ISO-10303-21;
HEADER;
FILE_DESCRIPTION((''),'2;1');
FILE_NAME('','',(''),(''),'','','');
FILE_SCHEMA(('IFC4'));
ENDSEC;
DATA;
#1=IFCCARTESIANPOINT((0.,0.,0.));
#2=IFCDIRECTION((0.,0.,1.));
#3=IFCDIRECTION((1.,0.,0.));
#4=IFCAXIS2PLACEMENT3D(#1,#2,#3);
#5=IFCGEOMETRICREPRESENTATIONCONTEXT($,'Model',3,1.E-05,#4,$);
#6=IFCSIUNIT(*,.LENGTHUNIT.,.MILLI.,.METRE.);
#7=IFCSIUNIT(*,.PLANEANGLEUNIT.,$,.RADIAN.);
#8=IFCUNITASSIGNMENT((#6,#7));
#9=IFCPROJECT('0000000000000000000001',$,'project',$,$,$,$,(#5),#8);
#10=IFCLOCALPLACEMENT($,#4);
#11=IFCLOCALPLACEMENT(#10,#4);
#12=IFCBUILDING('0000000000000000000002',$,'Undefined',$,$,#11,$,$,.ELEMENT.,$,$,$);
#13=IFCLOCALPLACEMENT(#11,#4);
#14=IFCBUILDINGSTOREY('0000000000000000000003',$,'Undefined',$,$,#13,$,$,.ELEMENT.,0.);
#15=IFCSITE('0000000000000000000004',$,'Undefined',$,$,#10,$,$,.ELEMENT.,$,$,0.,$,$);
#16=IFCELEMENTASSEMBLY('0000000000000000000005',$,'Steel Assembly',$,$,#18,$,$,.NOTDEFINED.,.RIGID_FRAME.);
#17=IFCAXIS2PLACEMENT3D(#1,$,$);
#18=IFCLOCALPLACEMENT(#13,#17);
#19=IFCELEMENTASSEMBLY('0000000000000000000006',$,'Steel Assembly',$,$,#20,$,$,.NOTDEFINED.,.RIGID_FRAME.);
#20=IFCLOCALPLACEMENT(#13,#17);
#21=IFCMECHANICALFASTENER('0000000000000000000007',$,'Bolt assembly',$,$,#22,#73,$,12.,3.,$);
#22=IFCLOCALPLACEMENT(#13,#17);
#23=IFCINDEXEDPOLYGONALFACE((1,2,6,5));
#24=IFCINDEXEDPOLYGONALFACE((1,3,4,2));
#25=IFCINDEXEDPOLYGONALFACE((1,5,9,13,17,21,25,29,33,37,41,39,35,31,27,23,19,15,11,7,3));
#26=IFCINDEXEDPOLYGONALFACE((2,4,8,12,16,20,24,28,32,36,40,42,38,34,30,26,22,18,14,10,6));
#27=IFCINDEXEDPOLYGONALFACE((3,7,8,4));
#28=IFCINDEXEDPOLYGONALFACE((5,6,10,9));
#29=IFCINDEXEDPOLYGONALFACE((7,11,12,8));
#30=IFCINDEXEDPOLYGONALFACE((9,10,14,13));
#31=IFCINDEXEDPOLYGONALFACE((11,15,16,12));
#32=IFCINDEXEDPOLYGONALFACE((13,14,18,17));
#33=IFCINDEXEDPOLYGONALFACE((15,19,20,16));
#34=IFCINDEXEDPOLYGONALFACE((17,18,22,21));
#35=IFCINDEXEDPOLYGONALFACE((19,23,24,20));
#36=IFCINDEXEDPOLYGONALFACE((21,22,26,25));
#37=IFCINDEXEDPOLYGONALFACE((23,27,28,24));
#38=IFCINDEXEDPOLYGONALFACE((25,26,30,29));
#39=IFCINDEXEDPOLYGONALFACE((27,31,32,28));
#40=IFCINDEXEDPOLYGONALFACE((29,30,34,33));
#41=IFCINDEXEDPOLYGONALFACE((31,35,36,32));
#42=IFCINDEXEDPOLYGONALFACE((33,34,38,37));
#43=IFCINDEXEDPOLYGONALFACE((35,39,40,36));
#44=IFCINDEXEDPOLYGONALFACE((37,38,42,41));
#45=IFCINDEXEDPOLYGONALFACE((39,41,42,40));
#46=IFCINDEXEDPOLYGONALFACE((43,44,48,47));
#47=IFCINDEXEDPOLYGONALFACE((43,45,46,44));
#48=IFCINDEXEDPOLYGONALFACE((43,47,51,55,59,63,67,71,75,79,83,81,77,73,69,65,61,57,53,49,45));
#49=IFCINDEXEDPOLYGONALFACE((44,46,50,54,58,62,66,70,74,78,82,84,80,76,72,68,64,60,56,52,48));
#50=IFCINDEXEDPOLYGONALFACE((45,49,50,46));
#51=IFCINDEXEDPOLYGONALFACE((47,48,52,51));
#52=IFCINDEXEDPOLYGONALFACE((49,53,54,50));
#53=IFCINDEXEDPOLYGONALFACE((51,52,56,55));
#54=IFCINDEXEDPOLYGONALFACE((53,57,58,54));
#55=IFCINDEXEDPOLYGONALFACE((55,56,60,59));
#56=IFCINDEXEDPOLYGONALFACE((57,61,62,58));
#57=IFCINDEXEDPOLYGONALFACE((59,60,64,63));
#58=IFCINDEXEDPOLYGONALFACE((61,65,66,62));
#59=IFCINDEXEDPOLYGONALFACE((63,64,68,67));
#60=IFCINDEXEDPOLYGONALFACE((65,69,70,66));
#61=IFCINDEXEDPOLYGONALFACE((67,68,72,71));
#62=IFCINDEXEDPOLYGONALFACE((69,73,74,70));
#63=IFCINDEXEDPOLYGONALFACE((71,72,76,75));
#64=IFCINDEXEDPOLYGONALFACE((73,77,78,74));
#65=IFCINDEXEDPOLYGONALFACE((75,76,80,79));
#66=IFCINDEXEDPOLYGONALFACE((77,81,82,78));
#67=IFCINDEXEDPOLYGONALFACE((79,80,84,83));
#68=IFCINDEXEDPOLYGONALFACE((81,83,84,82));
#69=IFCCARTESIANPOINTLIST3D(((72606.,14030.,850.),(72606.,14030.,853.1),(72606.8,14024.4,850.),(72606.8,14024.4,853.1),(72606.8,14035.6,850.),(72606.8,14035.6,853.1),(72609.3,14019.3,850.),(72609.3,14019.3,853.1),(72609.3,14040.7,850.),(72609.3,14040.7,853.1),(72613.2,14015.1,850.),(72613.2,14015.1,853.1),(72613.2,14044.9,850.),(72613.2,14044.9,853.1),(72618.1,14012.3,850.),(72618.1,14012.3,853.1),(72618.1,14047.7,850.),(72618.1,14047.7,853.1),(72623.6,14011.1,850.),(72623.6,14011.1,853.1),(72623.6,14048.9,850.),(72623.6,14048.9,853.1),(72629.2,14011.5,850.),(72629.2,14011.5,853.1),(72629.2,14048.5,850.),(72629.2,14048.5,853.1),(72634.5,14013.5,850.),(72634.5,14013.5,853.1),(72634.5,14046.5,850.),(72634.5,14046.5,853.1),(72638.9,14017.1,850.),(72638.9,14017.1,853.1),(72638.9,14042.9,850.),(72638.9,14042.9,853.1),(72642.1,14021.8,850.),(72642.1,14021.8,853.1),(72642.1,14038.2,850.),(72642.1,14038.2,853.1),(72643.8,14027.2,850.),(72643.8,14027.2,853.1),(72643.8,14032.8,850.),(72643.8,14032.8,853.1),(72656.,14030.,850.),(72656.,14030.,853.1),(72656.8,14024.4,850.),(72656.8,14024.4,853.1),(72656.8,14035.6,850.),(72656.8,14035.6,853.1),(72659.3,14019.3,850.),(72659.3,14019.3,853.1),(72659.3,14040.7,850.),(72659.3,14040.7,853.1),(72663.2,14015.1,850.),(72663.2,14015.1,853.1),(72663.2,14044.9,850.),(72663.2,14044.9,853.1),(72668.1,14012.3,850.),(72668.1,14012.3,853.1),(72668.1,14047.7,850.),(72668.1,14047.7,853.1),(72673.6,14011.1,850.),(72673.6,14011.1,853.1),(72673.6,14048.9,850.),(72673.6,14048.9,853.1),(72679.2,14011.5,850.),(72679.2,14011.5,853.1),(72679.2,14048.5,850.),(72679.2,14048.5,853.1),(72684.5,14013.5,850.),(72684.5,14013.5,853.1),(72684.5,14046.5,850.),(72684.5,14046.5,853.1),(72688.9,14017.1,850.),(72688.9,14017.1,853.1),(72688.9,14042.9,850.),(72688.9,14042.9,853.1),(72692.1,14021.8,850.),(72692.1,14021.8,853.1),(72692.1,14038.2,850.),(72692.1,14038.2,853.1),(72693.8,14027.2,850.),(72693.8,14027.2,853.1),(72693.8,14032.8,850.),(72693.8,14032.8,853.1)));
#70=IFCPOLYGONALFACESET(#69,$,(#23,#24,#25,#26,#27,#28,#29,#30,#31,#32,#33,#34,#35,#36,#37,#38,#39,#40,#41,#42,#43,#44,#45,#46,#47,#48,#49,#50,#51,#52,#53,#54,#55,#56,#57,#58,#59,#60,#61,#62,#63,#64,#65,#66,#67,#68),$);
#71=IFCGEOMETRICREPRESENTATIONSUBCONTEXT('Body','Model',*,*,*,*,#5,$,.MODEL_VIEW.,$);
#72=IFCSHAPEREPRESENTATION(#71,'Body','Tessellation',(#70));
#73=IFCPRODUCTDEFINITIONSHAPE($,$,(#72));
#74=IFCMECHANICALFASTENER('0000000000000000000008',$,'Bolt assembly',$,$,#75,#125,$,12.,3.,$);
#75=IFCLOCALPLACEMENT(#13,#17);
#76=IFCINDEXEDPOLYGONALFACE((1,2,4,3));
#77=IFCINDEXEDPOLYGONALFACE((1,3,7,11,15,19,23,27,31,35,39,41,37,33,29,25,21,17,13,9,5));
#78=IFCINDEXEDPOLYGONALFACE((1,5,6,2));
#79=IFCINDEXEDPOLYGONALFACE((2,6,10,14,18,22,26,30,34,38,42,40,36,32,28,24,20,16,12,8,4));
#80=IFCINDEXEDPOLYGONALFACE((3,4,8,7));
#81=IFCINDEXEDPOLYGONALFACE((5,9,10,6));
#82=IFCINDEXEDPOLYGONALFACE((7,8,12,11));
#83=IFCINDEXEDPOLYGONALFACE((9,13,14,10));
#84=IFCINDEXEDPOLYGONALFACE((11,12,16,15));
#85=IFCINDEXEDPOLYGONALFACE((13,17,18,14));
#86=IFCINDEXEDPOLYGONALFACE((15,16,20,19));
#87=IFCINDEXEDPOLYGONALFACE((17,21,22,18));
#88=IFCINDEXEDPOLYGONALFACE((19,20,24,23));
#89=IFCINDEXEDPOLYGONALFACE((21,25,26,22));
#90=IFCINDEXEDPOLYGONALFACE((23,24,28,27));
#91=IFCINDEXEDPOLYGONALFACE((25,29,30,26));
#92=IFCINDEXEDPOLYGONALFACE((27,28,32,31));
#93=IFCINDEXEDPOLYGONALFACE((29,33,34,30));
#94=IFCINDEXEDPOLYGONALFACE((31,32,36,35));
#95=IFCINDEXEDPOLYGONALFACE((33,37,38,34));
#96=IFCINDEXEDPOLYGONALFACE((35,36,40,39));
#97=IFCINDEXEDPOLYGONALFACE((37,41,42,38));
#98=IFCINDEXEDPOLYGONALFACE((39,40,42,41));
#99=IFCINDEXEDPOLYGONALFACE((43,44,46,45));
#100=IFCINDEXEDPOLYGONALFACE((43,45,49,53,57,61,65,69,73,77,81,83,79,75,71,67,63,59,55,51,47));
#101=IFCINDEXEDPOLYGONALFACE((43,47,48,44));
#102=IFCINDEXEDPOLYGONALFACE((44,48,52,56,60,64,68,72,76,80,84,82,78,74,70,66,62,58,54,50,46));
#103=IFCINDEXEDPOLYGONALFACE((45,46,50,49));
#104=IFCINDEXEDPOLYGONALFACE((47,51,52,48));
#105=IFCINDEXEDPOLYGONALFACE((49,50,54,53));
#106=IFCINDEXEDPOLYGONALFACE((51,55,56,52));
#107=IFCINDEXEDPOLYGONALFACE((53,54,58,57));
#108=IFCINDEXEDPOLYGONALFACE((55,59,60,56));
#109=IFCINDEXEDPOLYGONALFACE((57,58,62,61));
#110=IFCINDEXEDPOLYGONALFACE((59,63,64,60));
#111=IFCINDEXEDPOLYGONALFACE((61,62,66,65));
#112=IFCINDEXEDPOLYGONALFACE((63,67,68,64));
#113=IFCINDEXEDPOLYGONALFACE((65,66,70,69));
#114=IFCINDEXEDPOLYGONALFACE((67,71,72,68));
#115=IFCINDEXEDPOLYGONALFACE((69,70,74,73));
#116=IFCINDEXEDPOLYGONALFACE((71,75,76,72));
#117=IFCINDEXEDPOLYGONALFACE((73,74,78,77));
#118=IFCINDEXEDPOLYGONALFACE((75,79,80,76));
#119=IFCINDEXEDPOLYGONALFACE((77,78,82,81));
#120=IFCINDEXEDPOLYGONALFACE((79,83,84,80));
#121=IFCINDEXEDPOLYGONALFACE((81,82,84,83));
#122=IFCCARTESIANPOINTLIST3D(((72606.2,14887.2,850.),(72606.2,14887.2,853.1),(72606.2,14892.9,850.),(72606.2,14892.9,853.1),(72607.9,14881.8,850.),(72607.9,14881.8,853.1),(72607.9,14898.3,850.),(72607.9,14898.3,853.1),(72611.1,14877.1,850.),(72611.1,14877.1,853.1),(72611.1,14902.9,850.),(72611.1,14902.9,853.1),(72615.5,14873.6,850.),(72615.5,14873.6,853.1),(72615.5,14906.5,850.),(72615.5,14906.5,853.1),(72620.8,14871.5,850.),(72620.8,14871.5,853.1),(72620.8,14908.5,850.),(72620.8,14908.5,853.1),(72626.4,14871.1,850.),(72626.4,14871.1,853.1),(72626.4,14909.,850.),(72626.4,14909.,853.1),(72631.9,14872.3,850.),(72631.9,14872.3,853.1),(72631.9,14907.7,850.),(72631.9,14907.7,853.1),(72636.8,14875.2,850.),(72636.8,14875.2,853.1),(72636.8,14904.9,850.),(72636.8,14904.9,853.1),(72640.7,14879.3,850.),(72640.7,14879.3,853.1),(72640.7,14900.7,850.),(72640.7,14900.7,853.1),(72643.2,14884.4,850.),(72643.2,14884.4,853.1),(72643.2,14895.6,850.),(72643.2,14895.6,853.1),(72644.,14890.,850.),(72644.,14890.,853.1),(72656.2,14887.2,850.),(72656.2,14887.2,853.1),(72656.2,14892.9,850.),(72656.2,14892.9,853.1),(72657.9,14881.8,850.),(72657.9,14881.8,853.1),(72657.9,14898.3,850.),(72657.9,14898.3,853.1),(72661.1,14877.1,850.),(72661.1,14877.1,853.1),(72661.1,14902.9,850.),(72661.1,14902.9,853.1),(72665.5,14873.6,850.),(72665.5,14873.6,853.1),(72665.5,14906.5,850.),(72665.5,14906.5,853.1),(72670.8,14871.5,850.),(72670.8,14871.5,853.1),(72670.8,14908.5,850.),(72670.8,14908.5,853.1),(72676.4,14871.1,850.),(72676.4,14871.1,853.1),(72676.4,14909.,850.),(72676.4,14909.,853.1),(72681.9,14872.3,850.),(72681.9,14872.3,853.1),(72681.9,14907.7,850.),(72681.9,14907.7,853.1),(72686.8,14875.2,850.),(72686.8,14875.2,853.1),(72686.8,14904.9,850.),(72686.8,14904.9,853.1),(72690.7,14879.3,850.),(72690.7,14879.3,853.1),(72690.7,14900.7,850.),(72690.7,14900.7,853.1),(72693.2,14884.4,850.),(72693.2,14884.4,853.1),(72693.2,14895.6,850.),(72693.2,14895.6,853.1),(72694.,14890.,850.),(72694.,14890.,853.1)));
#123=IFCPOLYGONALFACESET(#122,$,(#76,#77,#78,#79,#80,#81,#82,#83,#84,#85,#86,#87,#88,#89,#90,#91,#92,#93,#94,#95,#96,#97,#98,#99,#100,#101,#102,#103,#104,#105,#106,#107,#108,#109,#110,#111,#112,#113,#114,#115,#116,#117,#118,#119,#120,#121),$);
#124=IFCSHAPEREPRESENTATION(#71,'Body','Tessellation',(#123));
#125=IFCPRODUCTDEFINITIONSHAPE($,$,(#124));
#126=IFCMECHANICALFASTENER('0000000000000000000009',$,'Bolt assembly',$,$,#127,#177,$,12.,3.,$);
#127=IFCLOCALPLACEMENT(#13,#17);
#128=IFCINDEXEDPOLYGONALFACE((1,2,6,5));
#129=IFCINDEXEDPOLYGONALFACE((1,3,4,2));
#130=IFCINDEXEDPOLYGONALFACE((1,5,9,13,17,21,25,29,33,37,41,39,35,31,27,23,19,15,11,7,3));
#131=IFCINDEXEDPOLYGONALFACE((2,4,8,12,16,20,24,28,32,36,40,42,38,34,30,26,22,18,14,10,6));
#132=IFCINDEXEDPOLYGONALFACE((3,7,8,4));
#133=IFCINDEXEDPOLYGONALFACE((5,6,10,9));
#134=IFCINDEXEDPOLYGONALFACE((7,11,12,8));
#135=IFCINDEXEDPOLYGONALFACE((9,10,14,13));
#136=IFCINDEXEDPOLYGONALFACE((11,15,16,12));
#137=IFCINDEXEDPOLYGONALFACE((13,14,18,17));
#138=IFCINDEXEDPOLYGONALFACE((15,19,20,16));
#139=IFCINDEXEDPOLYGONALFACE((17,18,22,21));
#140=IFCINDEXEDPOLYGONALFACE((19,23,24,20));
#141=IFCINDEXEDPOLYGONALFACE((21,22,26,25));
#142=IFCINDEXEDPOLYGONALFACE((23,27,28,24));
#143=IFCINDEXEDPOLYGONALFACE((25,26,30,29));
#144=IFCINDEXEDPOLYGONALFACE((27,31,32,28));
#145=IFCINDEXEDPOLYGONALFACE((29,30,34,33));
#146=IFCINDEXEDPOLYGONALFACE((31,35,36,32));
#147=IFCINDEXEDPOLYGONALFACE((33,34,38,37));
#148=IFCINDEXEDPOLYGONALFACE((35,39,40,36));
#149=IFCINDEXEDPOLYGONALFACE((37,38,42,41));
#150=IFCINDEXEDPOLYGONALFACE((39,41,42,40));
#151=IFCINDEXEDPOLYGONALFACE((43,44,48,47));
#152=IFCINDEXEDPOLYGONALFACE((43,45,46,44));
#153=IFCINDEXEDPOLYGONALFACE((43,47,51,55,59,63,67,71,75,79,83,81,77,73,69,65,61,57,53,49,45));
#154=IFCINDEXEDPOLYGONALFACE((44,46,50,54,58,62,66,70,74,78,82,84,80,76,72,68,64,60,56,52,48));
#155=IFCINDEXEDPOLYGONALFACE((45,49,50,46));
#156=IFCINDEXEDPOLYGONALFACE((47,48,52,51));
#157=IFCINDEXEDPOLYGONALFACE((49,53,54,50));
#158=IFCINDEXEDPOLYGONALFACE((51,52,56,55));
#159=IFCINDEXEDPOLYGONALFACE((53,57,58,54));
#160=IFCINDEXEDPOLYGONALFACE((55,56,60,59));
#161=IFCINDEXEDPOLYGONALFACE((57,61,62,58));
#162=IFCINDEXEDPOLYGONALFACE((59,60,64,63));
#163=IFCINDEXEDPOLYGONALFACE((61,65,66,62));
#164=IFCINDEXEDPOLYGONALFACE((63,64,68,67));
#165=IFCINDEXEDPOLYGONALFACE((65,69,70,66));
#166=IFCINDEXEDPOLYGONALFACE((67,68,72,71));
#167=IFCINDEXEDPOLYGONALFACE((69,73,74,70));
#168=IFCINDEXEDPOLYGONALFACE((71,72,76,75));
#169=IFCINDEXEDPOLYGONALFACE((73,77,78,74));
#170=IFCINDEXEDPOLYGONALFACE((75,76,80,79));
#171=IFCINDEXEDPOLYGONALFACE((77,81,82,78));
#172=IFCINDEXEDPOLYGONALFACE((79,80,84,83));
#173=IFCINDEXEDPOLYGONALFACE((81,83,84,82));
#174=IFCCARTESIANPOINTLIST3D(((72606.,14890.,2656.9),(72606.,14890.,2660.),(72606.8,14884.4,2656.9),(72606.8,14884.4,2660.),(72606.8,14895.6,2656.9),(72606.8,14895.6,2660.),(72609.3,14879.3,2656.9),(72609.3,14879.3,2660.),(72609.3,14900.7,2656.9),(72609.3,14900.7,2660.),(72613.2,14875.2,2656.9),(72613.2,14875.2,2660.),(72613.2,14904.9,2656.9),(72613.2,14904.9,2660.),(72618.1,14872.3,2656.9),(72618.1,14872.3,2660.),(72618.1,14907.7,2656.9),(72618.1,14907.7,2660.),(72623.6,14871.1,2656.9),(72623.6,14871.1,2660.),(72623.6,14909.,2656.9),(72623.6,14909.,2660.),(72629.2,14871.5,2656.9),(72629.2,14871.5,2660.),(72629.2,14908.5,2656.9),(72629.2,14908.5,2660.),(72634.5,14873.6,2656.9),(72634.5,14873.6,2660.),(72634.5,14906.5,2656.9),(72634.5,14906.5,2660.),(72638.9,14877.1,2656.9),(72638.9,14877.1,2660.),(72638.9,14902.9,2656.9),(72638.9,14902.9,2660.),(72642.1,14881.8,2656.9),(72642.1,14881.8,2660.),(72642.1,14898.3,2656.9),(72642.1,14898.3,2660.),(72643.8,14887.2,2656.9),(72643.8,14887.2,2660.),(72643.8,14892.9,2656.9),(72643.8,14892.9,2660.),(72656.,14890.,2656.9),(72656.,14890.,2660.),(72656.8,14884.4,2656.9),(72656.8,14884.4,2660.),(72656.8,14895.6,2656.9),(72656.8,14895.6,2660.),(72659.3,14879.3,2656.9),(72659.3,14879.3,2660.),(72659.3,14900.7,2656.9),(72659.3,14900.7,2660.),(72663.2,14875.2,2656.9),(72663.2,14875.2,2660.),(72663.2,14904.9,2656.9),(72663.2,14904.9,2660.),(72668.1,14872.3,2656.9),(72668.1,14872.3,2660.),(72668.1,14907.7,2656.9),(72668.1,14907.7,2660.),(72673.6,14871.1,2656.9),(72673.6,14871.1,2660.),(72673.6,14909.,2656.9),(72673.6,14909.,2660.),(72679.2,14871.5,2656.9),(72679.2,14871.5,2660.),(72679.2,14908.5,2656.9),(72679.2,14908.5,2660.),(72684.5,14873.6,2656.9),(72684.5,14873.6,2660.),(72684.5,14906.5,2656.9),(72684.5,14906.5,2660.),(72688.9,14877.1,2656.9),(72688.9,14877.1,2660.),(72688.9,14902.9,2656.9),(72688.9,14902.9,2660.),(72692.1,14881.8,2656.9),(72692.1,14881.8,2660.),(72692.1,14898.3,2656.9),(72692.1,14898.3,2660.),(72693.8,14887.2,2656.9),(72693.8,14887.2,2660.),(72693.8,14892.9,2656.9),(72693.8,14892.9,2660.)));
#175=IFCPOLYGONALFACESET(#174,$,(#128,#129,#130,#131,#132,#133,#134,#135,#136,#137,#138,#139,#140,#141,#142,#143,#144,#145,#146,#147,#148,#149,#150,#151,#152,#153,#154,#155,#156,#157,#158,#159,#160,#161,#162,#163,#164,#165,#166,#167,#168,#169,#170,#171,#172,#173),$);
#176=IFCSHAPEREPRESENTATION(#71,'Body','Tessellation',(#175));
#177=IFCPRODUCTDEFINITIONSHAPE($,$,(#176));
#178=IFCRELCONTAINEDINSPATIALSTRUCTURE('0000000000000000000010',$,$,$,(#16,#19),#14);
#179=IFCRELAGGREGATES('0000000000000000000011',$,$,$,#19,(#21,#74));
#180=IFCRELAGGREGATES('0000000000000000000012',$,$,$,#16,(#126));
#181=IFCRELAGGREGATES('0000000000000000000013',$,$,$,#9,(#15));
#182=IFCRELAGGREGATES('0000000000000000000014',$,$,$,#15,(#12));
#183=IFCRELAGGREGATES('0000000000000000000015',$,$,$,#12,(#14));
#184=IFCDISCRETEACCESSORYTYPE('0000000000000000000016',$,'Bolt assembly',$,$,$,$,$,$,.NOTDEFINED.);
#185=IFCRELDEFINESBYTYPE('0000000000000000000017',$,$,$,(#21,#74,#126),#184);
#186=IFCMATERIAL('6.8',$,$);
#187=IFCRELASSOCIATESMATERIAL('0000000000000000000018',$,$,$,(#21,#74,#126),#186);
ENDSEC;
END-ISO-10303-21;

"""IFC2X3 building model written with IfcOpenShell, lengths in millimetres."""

from ifc_helpers import new_model, si_unit, frame, origin_with_axes, origin_2d_with_axis, place, context, subcontext, project, spatial, circle, extrude, source, transform, mapped, material, type_object, element, aggregate, save


model = new_model("IFC2X3")

# Units and contexts
model_context = context("Model", 3, precision=1e-05, world=origin_with_axes())
body_context = subcontext(model_context, "Body", "Model", "MODEL_VIEW")
ifc_project = project(units=[si_unit("LENGTHUNIT", "METRE", prefix="MILLI"), si_unit("PLANEANGLEUNIT", "RADIAN")], contexts=[model_context])

# Site, building, storey
site_placement = place(None, origin_with_axes())
site = spatial("IfcSite", under=ifc_project, at=site_placement, Name="Undefined", CompositionType="ELEMENT", RefElevation=0.0)
building_placement = place(site_placement, origin_with_axes())
building = spatial("IfcBuilding", under=site, at=building_placement, Name="Undefined", CompositionType="ELEMENT")
storey_placement = place(building_placement, origin_with_axes())
storey = spatial("IfcBuildingStorey", under=building, at=storey_placement, Name="Undefined", CompositionType="ELEMENT", Elevation=0.0)

# Element assemblies
assembly_1_placement = place(storey_placement, origin_with_axes())
assembly_1 = element("IfcElementAssembly", 1, at=assembly_1_placement, inside=storey, Name="Steel Assembly", AssemblyPlace="NOTDEFINED", PredefinedType="RIGID_FRAME")
assembly_2_placement = place(storey_placement, origin_with_axes())
assembly_2 = element("IfcElementAssembly", 2, at=assembly_2_placement, inside=storey, Name="Steel Assembly", AssemblyPlace="NOTDEFINED", PredefinedType="RIGID_FRAME")

# Shared definitions
ifc_material_1 = material(Name="6.8")
discrete_accessory_type_1 = type_object("IfcDiscreteAccessoryType", Name="Bolt assembly")

# Mechanical fasteners
shared_shape_1 = source(origin_with_axes(), body_context, "Body", "SweptSolid", [
    extrude(circle(Radius=19.0, at=origin_2d_with_axis()), frame((0.0, 0.0, 0.0), z_axis=(0.0, 1.0, 0.0), x_axis=(1.0, 0.0, 0.0)), (0.0, 0.0, 1.0), 3.1),
])
mechanical_fastener_1_placement = place(assembly_2_placement, frame((72675.0, 14030.0, 850.0), z_axis=(0.0, 1.0, 0.0), x_axis=(-1.0, 0.0, 0.0)))
mechanical_fastener_1 = element("IfcMechanicalFastener", 3, at=mechanical_fastener_1_placement, type_object=discrete_accessory_type_1, material=ifc_material_1, Name="Bolt assembly", NominalDiameter=12.0, NominalLength=3.0, context=body_context, shape_type="MappedRepresentation", body=[
    mapped(shared_shape_1, transform((0.0, 0.0, 0.0))),
    mapped(shared_shape_1, transform((50.0, 0.0, 0.0))),
])
mechanical_fastener_2_placement = place(assembly_2_placement, frame((72625.0, 14890.0, 850.0), z_axis=(0.0, -1.0, 0.0), x_axis=(1.0, 0.0, 0.0)))
mechanical_fastener_2 = element("IfcMechanicalFastener", 4, at=mechanical_fastener_2_placement, type_object=discrete_accessory_type_1, material=ifc_material_1, Name="Bolt assembly", NominalDiameter=12.0, NominalLength=3.0, context=body_context, shape_type="MappedRepresentation", body=[
    mapped(shared_shape_1, transform((0.0, 0.0, 0.0))),
    mapped(shared_shape_1, transform((50.0, 0.0, 0.0))),
])
mechanical_fastener_3_placement = place(assembly_1_placement, frame((72675.0, 14890.0, 2660.0), z_axis=(0.0, -1.0, 0.0), x_axis=(-1.0, 0.0, 0.0)))
mechanical_fastener_3 = element("IfcMechanicalFastener", 5, at=mechanical_fastener_3_placement, type_object=discrete_accessory_type_1, material=ifc_material_1, Name="Bolt assembly", NominalDiameter=12.0, NominalLength=3.0, context=body_context, shape_type="MappedRepresentation", body=[
    mapped(shared_shape_1, transform((0.0, 0.0, 0.0))),
    mapped(shared_shape_1, transform((50.0, 0.0, 0.0))),
])
aggregate(assembly_2, [mechanical_fastener_1, mechanical_fastener_2])
aggregate(assembly_1, [mechanical_fastener_3])

save(model, "model.ifc")
